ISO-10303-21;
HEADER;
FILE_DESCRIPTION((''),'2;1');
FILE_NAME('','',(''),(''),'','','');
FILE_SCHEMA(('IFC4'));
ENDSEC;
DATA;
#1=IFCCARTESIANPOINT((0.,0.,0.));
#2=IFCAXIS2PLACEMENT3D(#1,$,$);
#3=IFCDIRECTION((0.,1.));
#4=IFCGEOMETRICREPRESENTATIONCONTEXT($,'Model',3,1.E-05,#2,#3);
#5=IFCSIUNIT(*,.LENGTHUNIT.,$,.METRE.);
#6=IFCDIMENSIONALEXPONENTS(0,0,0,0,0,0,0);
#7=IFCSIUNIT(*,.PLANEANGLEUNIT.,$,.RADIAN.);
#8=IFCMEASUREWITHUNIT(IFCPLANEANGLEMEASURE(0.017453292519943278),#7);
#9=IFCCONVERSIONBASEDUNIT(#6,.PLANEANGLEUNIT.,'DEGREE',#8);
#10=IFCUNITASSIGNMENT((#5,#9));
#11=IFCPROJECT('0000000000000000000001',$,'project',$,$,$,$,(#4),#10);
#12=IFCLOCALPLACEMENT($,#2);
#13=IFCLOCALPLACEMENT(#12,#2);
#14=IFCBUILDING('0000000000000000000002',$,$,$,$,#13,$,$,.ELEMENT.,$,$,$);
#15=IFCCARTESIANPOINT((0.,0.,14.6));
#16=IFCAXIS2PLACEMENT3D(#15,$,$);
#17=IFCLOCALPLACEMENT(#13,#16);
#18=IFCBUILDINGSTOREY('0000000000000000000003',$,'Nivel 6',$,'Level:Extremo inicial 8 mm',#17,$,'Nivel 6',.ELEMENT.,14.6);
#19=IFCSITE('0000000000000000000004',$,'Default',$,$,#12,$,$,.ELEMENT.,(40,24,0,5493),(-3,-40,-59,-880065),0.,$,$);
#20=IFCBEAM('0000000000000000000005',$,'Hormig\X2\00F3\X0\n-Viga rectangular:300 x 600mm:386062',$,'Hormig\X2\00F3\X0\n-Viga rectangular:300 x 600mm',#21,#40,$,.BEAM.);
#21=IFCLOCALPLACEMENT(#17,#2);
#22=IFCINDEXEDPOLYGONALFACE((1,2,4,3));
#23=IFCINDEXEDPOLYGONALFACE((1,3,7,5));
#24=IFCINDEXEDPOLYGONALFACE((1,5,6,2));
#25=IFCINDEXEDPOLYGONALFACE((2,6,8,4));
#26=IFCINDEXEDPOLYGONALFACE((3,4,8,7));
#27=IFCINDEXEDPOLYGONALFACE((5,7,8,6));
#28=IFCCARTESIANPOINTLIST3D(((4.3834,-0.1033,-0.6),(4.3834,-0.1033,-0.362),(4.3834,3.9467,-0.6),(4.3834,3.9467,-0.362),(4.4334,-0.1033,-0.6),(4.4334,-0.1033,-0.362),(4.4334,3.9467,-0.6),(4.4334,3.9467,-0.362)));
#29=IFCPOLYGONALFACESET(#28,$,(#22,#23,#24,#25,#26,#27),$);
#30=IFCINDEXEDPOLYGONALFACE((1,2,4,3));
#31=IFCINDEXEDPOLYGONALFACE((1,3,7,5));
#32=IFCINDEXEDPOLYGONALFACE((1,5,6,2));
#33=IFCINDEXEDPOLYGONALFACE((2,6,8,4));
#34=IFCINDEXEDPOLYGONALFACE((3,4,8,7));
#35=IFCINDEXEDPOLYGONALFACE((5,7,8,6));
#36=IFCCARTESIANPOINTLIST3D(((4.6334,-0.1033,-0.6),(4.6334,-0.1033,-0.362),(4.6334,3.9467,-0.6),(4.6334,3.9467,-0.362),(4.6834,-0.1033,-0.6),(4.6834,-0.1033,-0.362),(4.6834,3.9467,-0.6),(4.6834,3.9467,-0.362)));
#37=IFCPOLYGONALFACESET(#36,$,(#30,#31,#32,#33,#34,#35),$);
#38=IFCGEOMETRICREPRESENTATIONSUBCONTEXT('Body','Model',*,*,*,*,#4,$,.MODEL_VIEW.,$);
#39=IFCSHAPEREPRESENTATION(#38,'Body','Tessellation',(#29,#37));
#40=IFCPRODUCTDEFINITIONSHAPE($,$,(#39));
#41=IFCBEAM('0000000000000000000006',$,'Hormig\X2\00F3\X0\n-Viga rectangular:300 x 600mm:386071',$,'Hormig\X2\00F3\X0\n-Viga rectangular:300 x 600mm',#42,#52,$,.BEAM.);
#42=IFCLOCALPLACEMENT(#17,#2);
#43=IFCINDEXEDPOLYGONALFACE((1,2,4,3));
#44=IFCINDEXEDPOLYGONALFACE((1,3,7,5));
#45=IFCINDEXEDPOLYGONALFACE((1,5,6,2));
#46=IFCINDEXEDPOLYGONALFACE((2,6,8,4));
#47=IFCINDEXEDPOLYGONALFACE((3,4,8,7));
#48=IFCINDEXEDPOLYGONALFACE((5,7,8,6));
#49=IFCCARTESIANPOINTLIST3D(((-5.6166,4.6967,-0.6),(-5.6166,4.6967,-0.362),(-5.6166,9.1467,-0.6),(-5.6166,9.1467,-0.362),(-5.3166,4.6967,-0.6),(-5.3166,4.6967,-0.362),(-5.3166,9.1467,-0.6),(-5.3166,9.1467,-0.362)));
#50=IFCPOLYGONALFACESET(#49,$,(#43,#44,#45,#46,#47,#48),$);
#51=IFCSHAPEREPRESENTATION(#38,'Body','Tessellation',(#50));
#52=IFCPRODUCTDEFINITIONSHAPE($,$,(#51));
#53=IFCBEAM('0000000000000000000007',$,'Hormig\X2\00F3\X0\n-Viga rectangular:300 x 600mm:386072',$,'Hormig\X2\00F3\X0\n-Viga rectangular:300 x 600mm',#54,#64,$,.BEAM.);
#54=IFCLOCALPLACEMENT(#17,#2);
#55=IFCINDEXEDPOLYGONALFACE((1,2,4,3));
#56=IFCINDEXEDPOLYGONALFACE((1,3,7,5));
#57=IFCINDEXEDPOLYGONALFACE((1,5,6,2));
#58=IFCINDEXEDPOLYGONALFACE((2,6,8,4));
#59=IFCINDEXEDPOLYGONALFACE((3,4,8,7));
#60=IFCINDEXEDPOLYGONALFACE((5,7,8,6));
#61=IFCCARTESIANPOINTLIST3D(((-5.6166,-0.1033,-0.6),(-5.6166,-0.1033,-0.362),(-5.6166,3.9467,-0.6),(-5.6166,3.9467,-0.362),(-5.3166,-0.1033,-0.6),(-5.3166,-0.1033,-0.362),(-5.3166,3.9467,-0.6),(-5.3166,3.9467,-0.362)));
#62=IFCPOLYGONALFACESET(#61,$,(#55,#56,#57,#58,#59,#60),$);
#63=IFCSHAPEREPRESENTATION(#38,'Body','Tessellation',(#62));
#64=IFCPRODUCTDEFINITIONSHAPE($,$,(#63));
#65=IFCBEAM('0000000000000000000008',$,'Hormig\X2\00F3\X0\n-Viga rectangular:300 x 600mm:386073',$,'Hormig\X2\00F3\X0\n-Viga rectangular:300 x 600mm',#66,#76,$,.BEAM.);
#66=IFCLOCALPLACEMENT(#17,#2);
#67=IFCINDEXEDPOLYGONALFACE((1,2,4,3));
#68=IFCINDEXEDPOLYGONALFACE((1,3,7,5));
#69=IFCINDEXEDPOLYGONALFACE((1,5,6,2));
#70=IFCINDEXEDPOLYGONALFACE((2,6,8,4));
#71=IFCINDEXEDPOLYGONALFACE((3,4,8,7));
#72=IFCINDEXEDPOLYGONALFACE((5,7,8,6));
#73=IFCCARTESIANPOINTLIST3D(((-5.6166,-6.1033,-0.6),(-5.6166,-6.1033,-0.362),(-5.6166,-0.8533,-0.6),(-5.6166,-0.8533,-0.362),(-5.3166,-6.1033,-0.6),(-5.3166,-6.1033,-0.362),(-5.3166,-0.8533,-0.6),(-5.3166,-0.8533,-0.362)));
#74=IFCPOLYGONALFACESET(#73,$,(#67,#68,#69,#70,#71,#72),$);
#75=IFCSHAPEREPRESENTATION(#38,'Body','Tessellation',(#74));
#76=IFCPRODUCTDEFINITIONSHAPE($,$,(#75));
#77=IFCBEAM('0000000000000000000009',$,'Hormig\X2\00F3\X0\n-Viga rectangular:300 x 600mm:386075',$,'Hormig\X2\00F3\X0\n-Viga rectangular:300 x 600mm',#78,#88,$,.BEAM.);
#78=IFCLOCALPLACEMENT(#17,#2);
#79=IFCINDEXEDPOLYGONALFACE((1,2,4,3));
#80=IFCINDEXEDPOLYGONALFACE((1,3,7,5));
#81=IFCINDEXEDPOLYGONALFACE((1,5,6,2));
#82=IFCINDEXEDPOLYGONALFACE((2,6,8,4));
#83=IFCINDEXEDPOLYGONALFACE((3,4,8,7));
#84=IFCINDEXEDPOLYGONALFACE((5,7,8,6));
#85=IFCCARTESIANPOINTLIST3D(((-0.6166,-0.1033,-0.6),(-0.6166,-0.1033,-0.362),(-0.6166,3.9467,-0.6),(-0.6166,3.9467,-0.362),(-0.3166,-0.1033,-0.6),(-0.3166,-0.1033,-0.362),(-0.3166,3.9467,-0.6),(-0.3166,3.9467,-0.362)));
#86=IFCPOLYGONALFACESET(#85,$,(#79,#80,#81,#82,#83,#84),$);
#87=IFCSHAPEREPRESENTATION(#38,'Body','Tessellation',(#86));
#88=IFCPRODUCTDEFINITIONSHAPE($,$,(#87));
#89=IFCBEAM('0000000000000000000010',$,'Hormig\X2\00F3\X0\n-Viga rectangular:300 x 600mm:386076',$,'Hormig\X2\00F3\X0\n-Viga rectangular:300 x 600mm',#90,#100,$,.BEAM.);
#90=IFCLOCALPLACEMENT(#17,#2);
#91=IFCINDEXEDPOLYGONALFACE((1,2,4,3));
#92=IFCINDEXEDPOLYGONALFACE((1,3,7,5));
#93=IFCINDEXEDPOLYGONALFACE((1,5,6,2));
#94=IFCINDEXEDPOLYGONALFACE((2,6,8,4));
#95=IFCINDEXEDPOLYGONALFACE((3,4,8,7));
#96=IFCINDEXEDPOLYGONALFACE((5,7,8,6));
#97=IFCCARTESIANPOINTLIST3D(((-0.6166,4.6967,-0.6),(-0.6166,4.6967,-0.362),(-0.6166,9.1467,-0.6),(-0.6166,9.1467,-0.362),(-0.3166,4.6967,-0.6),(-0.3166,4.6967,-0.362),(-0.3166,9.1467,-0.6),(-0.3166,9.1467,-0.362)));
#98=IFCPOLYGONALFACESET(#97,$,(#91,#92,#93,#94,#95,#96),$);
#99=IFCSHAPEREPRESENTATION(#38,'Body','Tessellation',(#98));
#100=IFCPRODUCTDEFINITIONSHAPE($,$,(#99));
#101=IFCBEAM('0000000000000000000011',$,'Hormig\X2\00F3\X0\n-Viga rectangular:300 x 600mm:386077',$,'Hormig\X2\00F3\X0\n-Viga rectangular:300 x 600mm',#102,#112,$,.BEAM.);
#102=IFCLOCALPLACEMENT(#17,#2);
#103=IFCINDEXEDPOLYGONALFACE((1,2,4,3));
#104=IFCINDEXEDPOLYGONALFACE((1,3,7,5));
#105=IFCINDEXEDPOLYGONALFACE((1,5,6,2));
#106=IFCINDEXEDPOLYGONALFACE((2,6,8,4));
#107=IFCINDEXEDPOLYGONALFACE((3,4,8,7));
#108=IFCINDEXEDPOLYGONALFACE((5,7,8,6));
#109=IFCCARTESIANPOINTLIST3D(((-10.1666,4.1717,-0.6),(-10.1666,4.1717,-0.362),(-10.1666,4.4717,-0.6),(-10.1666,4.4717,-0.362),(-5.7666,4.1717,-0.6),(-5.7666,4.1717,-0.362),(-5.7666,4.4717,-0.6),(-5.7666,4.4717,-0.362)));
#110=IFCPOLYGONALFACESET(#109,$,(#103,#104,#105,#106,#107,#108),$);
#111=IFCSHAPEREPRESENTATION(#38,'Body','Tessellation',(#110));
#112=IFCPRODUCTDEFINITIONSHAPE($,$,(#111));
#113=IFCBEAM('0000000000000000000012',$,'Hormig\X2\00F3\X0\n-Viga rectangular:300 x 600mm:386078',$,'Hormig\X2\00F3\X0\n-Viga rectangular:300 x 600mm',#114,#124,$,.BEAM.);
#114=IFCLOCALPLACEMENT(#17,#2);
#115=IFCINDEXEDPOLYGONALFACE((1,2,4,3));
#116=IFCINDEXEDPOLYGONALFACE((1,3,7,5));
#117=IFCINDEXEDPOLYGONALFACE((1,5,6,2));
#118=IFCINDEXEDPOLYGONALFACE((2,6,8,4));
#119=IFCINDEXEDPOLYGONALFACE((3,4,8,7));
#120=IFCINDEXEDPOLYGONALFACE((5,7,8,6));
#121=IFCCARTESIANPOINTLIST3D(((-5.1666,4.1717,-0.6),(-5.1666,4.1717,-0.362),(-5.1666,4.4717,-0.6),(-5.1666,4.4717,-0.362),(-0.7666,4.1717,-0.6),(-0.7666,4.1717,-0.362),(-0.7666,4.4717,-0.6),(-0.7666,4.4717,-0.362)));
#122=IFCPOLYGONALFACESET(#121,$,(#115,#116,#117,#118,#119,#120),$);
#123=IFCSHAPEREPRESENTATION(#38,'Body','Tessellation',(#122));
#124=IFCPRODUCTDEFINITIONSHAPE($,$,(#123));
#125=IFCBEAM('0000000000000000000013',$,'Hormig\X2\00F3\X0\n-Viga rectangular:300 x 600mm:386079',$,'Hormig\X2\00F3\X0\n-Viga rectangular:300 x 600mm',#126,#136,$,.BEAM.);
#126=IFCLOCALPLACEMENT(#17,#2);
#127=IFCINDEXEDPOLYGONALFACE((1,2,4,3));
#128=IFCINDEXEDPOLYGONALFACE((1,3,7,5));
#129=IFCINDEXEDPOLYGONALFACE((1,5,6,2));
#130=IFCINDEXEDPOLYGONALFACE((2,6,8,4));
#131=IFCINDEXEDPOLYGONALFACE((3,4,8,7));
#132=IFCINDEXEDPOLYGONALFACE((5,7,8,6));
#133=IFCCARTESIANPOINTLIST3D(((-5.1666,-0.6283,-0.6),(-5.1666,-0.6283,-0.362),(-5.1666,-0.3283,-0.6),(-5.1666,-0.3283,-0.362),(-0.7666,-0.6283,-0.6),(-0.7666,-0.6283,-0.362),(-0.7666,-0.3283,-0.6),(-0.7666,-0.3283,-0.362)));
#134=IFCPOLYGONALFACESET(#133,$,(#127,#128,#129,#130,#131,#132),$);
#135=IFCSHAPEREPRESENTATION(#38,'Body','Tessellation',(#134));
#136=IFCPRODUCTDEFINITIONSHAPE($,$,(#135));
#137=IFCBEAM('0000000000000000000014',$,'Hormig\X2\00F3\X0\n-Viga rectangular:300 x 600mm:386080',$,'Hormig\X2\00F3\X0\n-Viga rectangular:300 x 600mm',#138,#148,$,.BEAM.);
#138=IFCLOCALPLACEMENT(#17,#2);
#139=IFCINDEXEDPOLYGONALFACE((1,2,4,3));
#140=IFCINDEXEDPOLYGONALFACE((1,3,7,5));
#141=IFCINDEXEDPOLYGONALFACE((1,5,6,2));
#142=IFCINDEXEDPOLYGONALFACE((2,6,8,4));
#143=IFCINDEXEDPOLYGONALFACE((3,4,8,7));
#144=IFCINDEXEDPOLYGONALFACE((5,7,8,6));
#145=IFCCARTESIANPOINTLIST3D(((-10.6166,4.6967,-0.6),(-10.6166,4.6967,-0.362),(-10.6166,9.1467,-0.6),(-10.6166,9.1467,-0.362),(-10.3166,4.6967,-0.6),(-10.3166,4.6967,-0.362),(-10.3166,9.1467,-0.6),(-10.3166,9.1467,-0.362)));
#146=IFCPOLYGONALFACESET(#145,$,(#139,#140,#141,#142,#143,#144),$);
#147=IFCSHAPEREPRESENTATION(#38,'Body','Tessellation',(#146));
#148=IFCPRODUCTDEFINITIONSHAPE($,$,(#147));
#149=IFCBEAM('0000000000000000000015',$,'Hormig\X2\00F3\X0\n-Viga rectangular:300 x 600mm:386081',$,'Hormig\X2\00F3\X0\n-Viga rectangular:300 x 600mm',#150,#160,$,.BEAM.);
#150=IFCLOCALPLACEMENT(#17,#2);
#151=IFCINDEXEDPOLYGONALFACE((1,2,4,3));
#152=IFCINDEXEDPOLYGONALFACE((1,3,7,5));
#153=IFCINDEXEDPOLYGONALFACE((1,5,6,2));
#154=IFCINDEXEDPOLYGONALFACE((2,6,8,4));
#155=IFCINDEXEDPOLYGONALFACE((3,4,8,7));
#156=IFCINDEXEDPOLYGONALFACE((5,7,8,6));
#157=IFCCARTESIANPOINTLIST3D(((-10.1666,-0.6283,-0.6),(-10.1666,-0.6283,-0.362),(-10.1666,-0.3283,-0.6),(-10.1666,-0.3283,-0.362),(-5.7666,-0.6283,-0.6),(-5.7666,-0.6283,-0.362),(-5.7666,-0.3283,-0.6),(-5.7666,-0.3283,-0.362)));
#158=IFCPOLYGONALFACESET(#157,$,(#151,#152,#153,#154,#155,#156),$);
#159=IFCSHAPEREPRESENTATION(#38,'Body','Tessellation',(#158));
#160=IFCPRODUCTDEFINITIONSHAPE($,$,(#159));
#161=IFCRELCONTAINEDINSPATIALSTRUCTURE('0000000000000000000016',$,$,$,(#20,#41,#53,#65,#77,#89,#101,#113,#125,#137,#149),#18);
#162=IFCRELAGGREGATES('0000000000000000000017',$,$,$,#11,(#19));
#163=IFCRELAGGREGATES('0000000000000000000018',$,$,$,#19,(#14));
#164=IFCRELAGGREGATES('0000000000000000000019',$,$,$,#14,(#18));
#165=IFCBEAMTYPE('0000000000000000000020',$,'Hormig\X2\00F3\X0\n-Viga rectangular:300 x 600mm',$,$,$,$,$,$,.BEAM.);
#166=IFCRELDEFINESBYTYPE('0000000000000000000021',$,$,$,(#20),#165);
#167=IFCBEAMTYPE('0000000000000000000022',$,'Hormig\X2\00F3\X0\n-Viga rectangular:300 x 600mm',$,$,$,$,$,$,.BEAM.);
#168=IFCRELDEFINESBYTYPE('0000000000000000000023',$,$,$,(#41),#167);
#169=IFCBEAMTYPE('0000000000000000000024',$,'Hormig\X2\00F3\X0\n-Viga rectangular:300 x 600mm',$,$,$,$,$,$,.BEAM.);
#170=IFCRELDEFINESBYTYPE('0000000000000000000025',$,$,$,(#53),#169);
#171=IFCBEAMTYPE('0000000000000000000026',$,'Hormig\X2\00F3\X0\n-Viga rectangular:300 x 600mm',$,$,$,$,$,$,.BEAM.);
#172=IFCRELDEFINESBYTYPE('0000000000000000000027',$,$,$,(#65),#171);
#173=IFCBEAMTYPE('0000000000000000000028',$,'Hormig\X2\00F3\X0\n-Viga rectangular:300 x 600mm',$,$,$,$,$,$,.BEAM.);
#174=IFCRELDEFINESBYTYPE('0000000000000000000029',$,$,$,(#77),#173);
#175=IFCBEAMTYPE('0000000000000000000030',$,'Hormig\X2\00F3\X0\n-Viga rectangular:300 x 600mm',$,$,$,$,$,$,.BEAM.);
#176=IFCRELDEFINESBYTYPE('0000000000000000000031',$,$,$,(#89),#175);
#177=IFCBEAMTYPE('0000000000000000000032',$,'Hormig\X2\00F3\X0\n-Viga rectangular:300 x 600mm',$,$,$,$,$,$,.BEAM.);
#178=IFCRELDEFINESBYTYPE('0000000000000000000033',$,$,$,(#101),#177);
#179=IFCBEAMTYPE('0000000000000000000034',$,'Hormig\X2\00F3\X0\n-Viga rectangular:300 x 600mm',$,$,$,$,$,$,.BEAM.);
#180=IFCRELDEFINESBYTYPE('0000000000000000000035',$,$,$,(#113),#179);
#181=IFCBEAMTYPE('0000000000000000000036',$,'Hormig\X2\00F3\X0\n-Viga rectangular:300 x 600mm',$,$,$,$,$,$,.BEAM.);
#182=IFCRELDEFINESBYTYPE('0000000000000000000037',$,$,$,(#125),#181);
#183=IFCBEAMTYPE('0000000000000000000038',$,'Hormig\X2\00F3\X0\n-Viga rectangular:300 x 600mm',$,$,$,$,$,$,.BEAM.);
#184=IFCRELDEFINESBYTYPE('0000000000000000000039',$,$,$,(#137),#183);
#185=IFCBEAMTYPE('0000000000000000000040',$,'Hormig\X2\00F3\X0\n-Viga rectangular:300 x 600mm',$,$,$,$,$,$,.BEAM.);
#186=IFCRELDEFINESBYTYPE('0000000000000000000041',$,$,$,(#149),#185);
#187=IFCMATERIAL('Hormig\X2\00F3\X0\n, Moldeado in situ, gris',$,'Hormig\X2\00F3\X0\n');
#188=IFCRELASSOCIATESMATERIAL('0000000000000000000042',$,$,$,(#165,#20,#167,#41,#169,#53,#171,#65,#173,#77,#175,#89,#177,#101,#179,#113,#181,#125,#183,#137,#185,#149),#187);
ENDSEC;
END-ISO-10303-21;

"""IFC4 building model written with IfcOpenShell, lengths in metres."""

from ifc_helpers import new_model, entity, si_unit, converted_unit, direction, frame, origin, place, context, subcontext, project, spatial, indexed_curve, outline, extrude, source, transform, mapped, material, type_object, type_shapes, element, save


model = new_model("IFC4")

# Units and contexts
model_context = context("Model", 3, precision=1e-05, world=origin(), true_north=direction((0.0, 1.0)))
body_context = subcontext(model_context, "Body", "Model", "MODEL_VIEW")
ifc_project = project(units=[si_unit("LENGTHUNIT", "METRE"), converted_unit("PLANEANGLEUNIT", "DEGREE", entity("IfcPlaneAngleMeasure", 0.017453292519943278), si_unit("PLANEANGLEUNIT", "RADIAN"), dimensions=[0, 0, 0, 0, 0, 0, 0])], contexts=[model_context])

# Site, building, storey
site_placement = place(None, origin())
site = spatial("IfcSite", under=ifc_project, at=site_placement, Name="Default", CompositionType="ELEMENT", RefLatitude=(40, 24, 0, 5493), RefLongitude=(-3, -40, -59, -880065), RefElevation=0.0)
building_placement = place(site_placement, origin())
building = spatial("IfcBuilding", under=site, at=building_placement, CompositionType="ELEMENT")
storey_placement = place(building_placement, frame((0.0, 0.0, 14.6)))
storey = spatial("IfcBuildingStorey", under=building, at=storey_placement, Name="Nivel 6", ObjectType="Level:Extremo inicial 8 mm", LongName="Nivel 6", CompositionType="ELEMENT", Elevation=14.6)

# Shared definitions
ifc_material_1 = material(Name="Hormigón, Moldeado in situ, gris", Category="Hormigón")

# Beams
beam_type_1 = type_object("IfcBeamType", Name="Hormigón-Viga rectangular:300 x 600mm", PredefinedType="BEAM", material=ifc_material_1)
shared_shape_1 = source(origin(), body_context, "Body", "SweptSolid", [
    extrude(outline(indexed_curve([(-0.025, -0.119), (0.025, -0.119), (0.025, 0.119), (-0.025, 0.119), (-0.025, -0.119)], self_intersect=False)), frame((4.4084, 3.9467, 14.119), z_axis=(0.0, -1.0, 0.0), x_axis=(-1.0, 0.0, 0.0)), (0.0, 0.0, 1.0), 4.05),
    extrude(outline(indexed_curve([(-0.025, -0.119), (0.025, -0.119), (0.025, 0.119), (-0.025, 0.119), (-0.025, -0.119)], self_intersect=False)), frame((4.6584, 3.9467, 14.119), z_axis=(0.0, -1.0, 0.0), x_axis=(-1.0, 0.0, 0.0)), (0.0, 0.0, 1.0), 4.05),
])
type_shapes(beam_type_1, [shared_shape_1])
beam_1_placement = place(storey_placement, frame((0.0, 0.0, -14.6)))
element("IfcBeam", 1, at=beam_1_placement, inside=storey, type_object=beam_type_1, material=ifc_material_1, Name="Hormigón-Viga rectangular:300 x 600mm:386062", ObjectType="Hormigón-Viga rectangular:300 x 600mm", PredefinedType="BEAM", context=body_context, shape_type="MappedRepresentation", body=[
    mapped(shared_shape_1, transform((0.0, 0.0, 0.0), scale=1.0)),
])
beam_type_2 = type_object("IfcBeamType", Name="Hormigón-Viga rectangular:300 x 600mm", PredefinedType="BEAM", material=ifc_material_1)
shared_shape_2 = source(origin(), body_context, "Body", "SweptSolid", [
    extrude(outline(indexed_curve([(-0.15, -0.119), (0.15, -0.119), (0.15, 0.119), (-0.15, 0.119), (-0.15, -0.119)], self_intersect=False)), frame((-5.4666, 9.1467, 14.119), z_axis=(0.0, -1.0, 0.0), x_axis=(-1.0, 0.0, 0.0)), (0.0, 0.0, 1.0), 4.45),
])
type_shapes(beam_type_2, [shared_shape_2])
beam_2_placement = place(storey_placement, frame((0.0, 0.0, -14.6)))
element("IfcBeam", 2, at=beam_2_placement, inside=storey, type_object=beam_type_2, material=ifc_material_1, Name="Hormigón-Viga rectangular:300 x 600mm:386071", ObjectType="Hormigón-Viga rectangular:300 x 600mm", PredefinedType="BEAM", context=body_context, shape_type="MappedRepresentation", body=[
    mapped(shared_shape_2, transform((0.0, 0.0, 0.0), scale=1.0)),
])
beam_type_3 = type_object("IfcBeamType", Name="Hormigón-Viga rectangular:300 x 600mm", PredefinedType="BEAM", material=ifc_material_1)
shared_shape_3 = source(origin(), body_context, "Body", "SweptSolid", [
    extrude(outline(indexed_curve([(-0.15, -0.119), (0.15, -0.119), (0.15, 0.119), (-0.15, 0.119), (-0.15, -0.119)], self_intersect=False)), frame((-5.4666, 3.9467, 14.119), z_axis=(0.0, -1.0, 0.0), x_axis=(-1.0, 0.0, 0.0)), (0.0, 0.0, 1.0), 4.05),
])
type_shapes(beam_type_3, [shared_shape_3])
beam_3_placement = place(storey_placement, frame((0.0, 0.0, -14.6)))
element("IfcBeam", 3, at=beam_3_placement, inside=storey, type_object=beam_type_3, material=ifc_material_1, Name="Hormigón-Viga rectangular:300 x 600mm:386072", ObjectType="Hormigón-Viga rectangular:300 x 600mm", PredefinedType="BEAM", context=body_context, shape_type="MappedRepresentation", body=[
    mapped(shared_shape_3, transform((0.0, 0.0, 0.0), scale=1.0)),
])
beam_type_4 = type_object("IfcBeamType", Name="Hormigón-Viga rectangular:300 x 600mm", PredefinedType="BEAM", material=ifc_material_1)
shared_shape_4 = source(origin(), body_context, "Body", "SweptSolid", [
    extrude(outline(indexed_curve([(-0.15, -0.119), (0.15, -0.119), (0.15, 0.119), (-0.15, 0.119), (-0.15, -0.119)], self_intersect=False)), frame((-5.4666, -6.1033, 14.119), z_axis=(0.0, 1.0, 0.0), x_axis=(-1.0, 0.0, 0.0)), (0.0, 0.0, 1.0), 5.25),
])
type_shapes(beam_type_4, [shared_shape_4])
beam_4_placement = place(storey_placement, frame((0.0, 0.0, -14.6)))
element("IfcBeam", 4, at=beam_4_placement, inside=storey, type_object=beam_type_4, material=ifc_material_1, Name="Hormigón-Viga rectangular:300 x 600mm:386073", ObjectType="Hormigón-Viga rectangular:300 x 600mm", PredefinedType="BEAM", context=body_context, shape_type="MappedRepresentation", body=[
    mapped(shared_shape_4, transform((0.0, 0.0, 0.0), scale=1.0)),
])
beam_type_5 = type_object("IfcBeamType", Name="Hormigón-Viga rectangular:300 x 600mm", PredefinedType="BEAM", material=ifc_material_1)
shared_shape_5 = source(origin(), body_context, "Body", "SweptSolid", [
    extrude(outline(indexed_curve([(-0.15, -0.119), (0.15, -0.119), (0.15, 0.119), (-0.15, 0.119), (-0.15, -0.119)], self_intersect=False)), frame((-0.4666, -0.1033, 14.119), z_axis=(0.0, 1.0, 0.0), x_axis=(-1.0, 0.0, 0.0)), (0.0, 0.0, 1.0), 4.05),
])
type_shapes(beam_type_5, [shared_shape_5])
beam_5_placement = place(storey_placement, frame((0.0, 0.0, -14.6)))
element("IfcBeam", 5, at=beam_5_placement, inside=storey, type_object=beam_type_5, material=ifc_material_1, Name="Hormigón-Viga rectangular:300 x 600mm:386075", ObjectType="Hormigón-Viga rectangular:300 x 600mm", PredefinedType="BEAM", context=body_context, shape_type="MappedRepresentation", body=[
    mapped(shared_shape_5, transform((0.0, 0.0, 0.0), scale=1.0)),
])
beam_type_6 = type_object("IfcBeamType", Name="Hormigón-Viga rectangular:300 x 600mm", PredefinedType="BEAM", material=ifc_material_1)
shared_shape_6 = source(origin(), body_context, "Body", "SweptSolid", [
    extrude(outline(indexed_curve([(-0.15, -0.119), (0.15, -0.119), (0.15, 0.119), (-0.15, 0.119), (-0.15, -0.119)], self_intersect=False)), frame((-0.4666, 9.1467, 14.119), z_axis=(0.0, -1.0, 0.0), x_axis=(-1.0, 0.0, 0.0)), (0.0, 0.0, 1.0), 4.45),
])
type_shapes(beam_type_6, [shared_shape_6])
beam_6_placement = place(storey_placement, frame((0.0, 0.0, -14.6)))
element("IfcBeam", 6, at=beam_6_placement, inside=storey, type_object=beam_type_6, material=ifc_material_1, Name="Hormigón-Viga rectangular:300 x 600mm:386076", ObjectType="Hormigón-Viga rectangular:300 x 600mm", PredefinedType="BEAM", context=body_context, shape_type="MappedRepresentation", body=[
    mapped(shared_shape_6, transform((0.0, 0.0, 0.0), scale=1.0)),
])
beam_type_7 = type_object("IfcBeamType", Name="Hormigón-Viga rectangular:300 x 600mm", PredefinedType="BEAM", material=ifc_material_1)
shared_shape_7 = source(origin(), body_context, "Body", "SweptSolid", [
    extrude(outline(indexed_curve([(-0.119, -0.15), (0.119, -0.15), (0.119, 0.15), (-0.119, 0.15), (-0.119, -0.15)], self_intersect=False)), frame((-10.1666, 4.3217, 14.119), z_axis=(1.0, 0.0, 0.0), x_axis=(0.0, 0.0, -1.0)), (0.0, 0.0, 1.0), 4.4),
])
type_shapes(beam_type_7, [shared_shape_7])
beam_7_placement = place(storey_placement, frame((0.0, 0.0, -14.6)))
element("IfcBeam", 7, at=beam_7_placement, inside=storey, type_object=beam_type_7, material=ifc_material_1, Name="Hormigón-Viga rectangular:300 x 600mm:386077", ObjectType="Hormigón-Viga rectangular:300 x 600mm", PredefinedType="BEAM", context=body_context, shape_type="MappedRepresentation", body=[
    mapped(shared_shape_7, transform((0.0, 0.0, 0.0), scale=1.0)),
])
beam_type_8 = type_object("IfcBeamType", Name="Hormigón-Viga rectangular:300 x 600mm", PredefinedType="BEAM", material=ifc_material_1)
shared_shape_8 = source(origin(), body_context, "Body", "SweptSolid", [
    extrude(outline(indexed_curve([(-0.119, -0.15), (0.119, -0.15), (0.119, 0.15), (-0.119, 0.15), (-0.119, -0.15)], self_intersect=False)), frame((-5.1666, 4.3217, 14.119), z_axis=(1.0, 0.0, 0.0), x_axis=(0.0, 0.0, -1.0)), (0.0, 0.0, 1.0), 4.4),
])
type_shapes(beam_type_8, [shared_shape_8])
beam_8_placement = place(storey_placement, frame((0.0, 0.0, -14.6)))
element("IfcBeam", 8, at=beam_8_placement, inside=storey, type_object=beam_type_8, material=ifc_material_1, Name="Hormigón-Viga rectangular:300 x 600mm:386078", ObjectType="Hormigón-Viga rectangular:300 x 600mm", PredefinedType="BEAM", context=body_context, shape_type="MappedRepresentation", body=[
    mapped(shared_shape_8, transform((0.0, 0.0, 0.0), scale=1.0)),
])
beam_type_9 = type_object("IfcBeamType", Name="Hormigón-Viga rectangular:300 x 600mm", PredefinedType="BEAM", material=ifc_material_1)
shared_shape_9 = source(origin(), body_context, "Body", "SweptSolid", [
    extrude(outline(indexed_curve([(-0.119, -0.15), (0.119, -0.15), (0.119, 0.15), (-0.119, 0.15), (-0.119, -0.15)], self_intersect=False)), frame((-0.7666, -0.4783, 14.119), z_axis=(-1.0, 0.0, 0.0), x_axis=(0.0, 0.0, -1.0)), (0.0, 0.0, 1.0), 4.4),
])
type_shapes(beam_type_9, [shared_shape_9])
beam_9_placement = place(storey_placement, frame((0.0, 0.0, -14.6)))
element("IfcBeam", 9, at=beam_9_placement, inside=storey, type_object=beam_type_9, material=ifc_material_1, Name="Hormigón-Viga rectangular:300 x 600mm:386079", ObjectType="Hormigón-Viga rectangular:300 x 600mm", PredefinedType="BEAM", context=body_context, shape_type="MappedRepresentation", body=[
    mapped(shared_shape_9, transform((0.0, 0.0, 0.0), scale=1.0)),
])
beam_type_10 = type_object("IfcBeamType", Name="Hormigón-Viga rectangular:300 x 600mm", PredefinedType="BEAM", material=ifc_material_1)
shared_shape_10 = source(origin(), body_context, "Body", "SweptSolid", [
    extrude(outline(indexed_curve([(-0.15, -0.119), (0.15, -0.119), (0.15, 0.119), (-0.15, 0.119), (-0.15, -0.119)], self_intersect=False)), frame((-10.4666, 4.6967, 14.119), z_axis=(0.0, 1.0, 0.0), x_axis=(-1.0, 0.0, 0.0)), (0.0, 0.0, 1.0), 4.45),
])
type_shapes(beam_type_10, [shared_shape_10])
beam_10_placement = place(storey_placement, frame((0.0, 0.0, -14.6)))
element("IfcBeam", 10, at=beam_10_placement, inside=storey, type_object=beam_type_10, material=ifc_material_1, Name="Hormigón-Viga rectangular:300 x 600mm:386080", ObjectType="Hormigón-Viga rectangular:300 x 600mm", PredefinedType="BEAM", context=body_context, shape_type="MappedRepresentation", body=[
    mapped(shared_shape_10, transform((0.0, 0.0, 0.0), scale=1.0)),
])
beam_type_11 = type_object("IfcBeamType", Name="Hormigón-Viga rectangular:300 x 600mm", PredefinedType="BEAM", material=ifc_material_1)
shared_shape_11 = source(origin(), body_context, "Body", "SweptSolid", [
    extrude(outline(indexed_curve([(-0.119, -0.15), (0.119, -0.15), (0.119, 0.15), (-0.119, 0.15), (-0.119, -0.15)], self_intersect=False)), frame((-10.1666, -0.4783, 14.119), z_axis=(1.0, 0.0, 0.0), x_axis=(0.0, 0.0, -1.0)), (0.0, 0.0, 1.0), 4.4),
])
type_shapes(beam_type_11, [shared_shape_11])
beam_11_placement = place(storey_placement, frame((0.0, 0.0, -14.6)))
element("IfcBeam", 11, at=beam_11_placement, inside=storey, type_object=beam_type_11, material=ifc_material_1, Name="Hormigón-Viga rectangular:300 x 600mm:386081", ObjectType="Hormigón-Viga rectangular:300 x 600mm", PredefinedType="BEAM", context=body_context, shape_type="MappedRepresentation", body=[
    mapped(shared_shape_11, transform((0.0, 0.0, 0.0), scale=1.0)),
])

save(model, "model.ifc")
